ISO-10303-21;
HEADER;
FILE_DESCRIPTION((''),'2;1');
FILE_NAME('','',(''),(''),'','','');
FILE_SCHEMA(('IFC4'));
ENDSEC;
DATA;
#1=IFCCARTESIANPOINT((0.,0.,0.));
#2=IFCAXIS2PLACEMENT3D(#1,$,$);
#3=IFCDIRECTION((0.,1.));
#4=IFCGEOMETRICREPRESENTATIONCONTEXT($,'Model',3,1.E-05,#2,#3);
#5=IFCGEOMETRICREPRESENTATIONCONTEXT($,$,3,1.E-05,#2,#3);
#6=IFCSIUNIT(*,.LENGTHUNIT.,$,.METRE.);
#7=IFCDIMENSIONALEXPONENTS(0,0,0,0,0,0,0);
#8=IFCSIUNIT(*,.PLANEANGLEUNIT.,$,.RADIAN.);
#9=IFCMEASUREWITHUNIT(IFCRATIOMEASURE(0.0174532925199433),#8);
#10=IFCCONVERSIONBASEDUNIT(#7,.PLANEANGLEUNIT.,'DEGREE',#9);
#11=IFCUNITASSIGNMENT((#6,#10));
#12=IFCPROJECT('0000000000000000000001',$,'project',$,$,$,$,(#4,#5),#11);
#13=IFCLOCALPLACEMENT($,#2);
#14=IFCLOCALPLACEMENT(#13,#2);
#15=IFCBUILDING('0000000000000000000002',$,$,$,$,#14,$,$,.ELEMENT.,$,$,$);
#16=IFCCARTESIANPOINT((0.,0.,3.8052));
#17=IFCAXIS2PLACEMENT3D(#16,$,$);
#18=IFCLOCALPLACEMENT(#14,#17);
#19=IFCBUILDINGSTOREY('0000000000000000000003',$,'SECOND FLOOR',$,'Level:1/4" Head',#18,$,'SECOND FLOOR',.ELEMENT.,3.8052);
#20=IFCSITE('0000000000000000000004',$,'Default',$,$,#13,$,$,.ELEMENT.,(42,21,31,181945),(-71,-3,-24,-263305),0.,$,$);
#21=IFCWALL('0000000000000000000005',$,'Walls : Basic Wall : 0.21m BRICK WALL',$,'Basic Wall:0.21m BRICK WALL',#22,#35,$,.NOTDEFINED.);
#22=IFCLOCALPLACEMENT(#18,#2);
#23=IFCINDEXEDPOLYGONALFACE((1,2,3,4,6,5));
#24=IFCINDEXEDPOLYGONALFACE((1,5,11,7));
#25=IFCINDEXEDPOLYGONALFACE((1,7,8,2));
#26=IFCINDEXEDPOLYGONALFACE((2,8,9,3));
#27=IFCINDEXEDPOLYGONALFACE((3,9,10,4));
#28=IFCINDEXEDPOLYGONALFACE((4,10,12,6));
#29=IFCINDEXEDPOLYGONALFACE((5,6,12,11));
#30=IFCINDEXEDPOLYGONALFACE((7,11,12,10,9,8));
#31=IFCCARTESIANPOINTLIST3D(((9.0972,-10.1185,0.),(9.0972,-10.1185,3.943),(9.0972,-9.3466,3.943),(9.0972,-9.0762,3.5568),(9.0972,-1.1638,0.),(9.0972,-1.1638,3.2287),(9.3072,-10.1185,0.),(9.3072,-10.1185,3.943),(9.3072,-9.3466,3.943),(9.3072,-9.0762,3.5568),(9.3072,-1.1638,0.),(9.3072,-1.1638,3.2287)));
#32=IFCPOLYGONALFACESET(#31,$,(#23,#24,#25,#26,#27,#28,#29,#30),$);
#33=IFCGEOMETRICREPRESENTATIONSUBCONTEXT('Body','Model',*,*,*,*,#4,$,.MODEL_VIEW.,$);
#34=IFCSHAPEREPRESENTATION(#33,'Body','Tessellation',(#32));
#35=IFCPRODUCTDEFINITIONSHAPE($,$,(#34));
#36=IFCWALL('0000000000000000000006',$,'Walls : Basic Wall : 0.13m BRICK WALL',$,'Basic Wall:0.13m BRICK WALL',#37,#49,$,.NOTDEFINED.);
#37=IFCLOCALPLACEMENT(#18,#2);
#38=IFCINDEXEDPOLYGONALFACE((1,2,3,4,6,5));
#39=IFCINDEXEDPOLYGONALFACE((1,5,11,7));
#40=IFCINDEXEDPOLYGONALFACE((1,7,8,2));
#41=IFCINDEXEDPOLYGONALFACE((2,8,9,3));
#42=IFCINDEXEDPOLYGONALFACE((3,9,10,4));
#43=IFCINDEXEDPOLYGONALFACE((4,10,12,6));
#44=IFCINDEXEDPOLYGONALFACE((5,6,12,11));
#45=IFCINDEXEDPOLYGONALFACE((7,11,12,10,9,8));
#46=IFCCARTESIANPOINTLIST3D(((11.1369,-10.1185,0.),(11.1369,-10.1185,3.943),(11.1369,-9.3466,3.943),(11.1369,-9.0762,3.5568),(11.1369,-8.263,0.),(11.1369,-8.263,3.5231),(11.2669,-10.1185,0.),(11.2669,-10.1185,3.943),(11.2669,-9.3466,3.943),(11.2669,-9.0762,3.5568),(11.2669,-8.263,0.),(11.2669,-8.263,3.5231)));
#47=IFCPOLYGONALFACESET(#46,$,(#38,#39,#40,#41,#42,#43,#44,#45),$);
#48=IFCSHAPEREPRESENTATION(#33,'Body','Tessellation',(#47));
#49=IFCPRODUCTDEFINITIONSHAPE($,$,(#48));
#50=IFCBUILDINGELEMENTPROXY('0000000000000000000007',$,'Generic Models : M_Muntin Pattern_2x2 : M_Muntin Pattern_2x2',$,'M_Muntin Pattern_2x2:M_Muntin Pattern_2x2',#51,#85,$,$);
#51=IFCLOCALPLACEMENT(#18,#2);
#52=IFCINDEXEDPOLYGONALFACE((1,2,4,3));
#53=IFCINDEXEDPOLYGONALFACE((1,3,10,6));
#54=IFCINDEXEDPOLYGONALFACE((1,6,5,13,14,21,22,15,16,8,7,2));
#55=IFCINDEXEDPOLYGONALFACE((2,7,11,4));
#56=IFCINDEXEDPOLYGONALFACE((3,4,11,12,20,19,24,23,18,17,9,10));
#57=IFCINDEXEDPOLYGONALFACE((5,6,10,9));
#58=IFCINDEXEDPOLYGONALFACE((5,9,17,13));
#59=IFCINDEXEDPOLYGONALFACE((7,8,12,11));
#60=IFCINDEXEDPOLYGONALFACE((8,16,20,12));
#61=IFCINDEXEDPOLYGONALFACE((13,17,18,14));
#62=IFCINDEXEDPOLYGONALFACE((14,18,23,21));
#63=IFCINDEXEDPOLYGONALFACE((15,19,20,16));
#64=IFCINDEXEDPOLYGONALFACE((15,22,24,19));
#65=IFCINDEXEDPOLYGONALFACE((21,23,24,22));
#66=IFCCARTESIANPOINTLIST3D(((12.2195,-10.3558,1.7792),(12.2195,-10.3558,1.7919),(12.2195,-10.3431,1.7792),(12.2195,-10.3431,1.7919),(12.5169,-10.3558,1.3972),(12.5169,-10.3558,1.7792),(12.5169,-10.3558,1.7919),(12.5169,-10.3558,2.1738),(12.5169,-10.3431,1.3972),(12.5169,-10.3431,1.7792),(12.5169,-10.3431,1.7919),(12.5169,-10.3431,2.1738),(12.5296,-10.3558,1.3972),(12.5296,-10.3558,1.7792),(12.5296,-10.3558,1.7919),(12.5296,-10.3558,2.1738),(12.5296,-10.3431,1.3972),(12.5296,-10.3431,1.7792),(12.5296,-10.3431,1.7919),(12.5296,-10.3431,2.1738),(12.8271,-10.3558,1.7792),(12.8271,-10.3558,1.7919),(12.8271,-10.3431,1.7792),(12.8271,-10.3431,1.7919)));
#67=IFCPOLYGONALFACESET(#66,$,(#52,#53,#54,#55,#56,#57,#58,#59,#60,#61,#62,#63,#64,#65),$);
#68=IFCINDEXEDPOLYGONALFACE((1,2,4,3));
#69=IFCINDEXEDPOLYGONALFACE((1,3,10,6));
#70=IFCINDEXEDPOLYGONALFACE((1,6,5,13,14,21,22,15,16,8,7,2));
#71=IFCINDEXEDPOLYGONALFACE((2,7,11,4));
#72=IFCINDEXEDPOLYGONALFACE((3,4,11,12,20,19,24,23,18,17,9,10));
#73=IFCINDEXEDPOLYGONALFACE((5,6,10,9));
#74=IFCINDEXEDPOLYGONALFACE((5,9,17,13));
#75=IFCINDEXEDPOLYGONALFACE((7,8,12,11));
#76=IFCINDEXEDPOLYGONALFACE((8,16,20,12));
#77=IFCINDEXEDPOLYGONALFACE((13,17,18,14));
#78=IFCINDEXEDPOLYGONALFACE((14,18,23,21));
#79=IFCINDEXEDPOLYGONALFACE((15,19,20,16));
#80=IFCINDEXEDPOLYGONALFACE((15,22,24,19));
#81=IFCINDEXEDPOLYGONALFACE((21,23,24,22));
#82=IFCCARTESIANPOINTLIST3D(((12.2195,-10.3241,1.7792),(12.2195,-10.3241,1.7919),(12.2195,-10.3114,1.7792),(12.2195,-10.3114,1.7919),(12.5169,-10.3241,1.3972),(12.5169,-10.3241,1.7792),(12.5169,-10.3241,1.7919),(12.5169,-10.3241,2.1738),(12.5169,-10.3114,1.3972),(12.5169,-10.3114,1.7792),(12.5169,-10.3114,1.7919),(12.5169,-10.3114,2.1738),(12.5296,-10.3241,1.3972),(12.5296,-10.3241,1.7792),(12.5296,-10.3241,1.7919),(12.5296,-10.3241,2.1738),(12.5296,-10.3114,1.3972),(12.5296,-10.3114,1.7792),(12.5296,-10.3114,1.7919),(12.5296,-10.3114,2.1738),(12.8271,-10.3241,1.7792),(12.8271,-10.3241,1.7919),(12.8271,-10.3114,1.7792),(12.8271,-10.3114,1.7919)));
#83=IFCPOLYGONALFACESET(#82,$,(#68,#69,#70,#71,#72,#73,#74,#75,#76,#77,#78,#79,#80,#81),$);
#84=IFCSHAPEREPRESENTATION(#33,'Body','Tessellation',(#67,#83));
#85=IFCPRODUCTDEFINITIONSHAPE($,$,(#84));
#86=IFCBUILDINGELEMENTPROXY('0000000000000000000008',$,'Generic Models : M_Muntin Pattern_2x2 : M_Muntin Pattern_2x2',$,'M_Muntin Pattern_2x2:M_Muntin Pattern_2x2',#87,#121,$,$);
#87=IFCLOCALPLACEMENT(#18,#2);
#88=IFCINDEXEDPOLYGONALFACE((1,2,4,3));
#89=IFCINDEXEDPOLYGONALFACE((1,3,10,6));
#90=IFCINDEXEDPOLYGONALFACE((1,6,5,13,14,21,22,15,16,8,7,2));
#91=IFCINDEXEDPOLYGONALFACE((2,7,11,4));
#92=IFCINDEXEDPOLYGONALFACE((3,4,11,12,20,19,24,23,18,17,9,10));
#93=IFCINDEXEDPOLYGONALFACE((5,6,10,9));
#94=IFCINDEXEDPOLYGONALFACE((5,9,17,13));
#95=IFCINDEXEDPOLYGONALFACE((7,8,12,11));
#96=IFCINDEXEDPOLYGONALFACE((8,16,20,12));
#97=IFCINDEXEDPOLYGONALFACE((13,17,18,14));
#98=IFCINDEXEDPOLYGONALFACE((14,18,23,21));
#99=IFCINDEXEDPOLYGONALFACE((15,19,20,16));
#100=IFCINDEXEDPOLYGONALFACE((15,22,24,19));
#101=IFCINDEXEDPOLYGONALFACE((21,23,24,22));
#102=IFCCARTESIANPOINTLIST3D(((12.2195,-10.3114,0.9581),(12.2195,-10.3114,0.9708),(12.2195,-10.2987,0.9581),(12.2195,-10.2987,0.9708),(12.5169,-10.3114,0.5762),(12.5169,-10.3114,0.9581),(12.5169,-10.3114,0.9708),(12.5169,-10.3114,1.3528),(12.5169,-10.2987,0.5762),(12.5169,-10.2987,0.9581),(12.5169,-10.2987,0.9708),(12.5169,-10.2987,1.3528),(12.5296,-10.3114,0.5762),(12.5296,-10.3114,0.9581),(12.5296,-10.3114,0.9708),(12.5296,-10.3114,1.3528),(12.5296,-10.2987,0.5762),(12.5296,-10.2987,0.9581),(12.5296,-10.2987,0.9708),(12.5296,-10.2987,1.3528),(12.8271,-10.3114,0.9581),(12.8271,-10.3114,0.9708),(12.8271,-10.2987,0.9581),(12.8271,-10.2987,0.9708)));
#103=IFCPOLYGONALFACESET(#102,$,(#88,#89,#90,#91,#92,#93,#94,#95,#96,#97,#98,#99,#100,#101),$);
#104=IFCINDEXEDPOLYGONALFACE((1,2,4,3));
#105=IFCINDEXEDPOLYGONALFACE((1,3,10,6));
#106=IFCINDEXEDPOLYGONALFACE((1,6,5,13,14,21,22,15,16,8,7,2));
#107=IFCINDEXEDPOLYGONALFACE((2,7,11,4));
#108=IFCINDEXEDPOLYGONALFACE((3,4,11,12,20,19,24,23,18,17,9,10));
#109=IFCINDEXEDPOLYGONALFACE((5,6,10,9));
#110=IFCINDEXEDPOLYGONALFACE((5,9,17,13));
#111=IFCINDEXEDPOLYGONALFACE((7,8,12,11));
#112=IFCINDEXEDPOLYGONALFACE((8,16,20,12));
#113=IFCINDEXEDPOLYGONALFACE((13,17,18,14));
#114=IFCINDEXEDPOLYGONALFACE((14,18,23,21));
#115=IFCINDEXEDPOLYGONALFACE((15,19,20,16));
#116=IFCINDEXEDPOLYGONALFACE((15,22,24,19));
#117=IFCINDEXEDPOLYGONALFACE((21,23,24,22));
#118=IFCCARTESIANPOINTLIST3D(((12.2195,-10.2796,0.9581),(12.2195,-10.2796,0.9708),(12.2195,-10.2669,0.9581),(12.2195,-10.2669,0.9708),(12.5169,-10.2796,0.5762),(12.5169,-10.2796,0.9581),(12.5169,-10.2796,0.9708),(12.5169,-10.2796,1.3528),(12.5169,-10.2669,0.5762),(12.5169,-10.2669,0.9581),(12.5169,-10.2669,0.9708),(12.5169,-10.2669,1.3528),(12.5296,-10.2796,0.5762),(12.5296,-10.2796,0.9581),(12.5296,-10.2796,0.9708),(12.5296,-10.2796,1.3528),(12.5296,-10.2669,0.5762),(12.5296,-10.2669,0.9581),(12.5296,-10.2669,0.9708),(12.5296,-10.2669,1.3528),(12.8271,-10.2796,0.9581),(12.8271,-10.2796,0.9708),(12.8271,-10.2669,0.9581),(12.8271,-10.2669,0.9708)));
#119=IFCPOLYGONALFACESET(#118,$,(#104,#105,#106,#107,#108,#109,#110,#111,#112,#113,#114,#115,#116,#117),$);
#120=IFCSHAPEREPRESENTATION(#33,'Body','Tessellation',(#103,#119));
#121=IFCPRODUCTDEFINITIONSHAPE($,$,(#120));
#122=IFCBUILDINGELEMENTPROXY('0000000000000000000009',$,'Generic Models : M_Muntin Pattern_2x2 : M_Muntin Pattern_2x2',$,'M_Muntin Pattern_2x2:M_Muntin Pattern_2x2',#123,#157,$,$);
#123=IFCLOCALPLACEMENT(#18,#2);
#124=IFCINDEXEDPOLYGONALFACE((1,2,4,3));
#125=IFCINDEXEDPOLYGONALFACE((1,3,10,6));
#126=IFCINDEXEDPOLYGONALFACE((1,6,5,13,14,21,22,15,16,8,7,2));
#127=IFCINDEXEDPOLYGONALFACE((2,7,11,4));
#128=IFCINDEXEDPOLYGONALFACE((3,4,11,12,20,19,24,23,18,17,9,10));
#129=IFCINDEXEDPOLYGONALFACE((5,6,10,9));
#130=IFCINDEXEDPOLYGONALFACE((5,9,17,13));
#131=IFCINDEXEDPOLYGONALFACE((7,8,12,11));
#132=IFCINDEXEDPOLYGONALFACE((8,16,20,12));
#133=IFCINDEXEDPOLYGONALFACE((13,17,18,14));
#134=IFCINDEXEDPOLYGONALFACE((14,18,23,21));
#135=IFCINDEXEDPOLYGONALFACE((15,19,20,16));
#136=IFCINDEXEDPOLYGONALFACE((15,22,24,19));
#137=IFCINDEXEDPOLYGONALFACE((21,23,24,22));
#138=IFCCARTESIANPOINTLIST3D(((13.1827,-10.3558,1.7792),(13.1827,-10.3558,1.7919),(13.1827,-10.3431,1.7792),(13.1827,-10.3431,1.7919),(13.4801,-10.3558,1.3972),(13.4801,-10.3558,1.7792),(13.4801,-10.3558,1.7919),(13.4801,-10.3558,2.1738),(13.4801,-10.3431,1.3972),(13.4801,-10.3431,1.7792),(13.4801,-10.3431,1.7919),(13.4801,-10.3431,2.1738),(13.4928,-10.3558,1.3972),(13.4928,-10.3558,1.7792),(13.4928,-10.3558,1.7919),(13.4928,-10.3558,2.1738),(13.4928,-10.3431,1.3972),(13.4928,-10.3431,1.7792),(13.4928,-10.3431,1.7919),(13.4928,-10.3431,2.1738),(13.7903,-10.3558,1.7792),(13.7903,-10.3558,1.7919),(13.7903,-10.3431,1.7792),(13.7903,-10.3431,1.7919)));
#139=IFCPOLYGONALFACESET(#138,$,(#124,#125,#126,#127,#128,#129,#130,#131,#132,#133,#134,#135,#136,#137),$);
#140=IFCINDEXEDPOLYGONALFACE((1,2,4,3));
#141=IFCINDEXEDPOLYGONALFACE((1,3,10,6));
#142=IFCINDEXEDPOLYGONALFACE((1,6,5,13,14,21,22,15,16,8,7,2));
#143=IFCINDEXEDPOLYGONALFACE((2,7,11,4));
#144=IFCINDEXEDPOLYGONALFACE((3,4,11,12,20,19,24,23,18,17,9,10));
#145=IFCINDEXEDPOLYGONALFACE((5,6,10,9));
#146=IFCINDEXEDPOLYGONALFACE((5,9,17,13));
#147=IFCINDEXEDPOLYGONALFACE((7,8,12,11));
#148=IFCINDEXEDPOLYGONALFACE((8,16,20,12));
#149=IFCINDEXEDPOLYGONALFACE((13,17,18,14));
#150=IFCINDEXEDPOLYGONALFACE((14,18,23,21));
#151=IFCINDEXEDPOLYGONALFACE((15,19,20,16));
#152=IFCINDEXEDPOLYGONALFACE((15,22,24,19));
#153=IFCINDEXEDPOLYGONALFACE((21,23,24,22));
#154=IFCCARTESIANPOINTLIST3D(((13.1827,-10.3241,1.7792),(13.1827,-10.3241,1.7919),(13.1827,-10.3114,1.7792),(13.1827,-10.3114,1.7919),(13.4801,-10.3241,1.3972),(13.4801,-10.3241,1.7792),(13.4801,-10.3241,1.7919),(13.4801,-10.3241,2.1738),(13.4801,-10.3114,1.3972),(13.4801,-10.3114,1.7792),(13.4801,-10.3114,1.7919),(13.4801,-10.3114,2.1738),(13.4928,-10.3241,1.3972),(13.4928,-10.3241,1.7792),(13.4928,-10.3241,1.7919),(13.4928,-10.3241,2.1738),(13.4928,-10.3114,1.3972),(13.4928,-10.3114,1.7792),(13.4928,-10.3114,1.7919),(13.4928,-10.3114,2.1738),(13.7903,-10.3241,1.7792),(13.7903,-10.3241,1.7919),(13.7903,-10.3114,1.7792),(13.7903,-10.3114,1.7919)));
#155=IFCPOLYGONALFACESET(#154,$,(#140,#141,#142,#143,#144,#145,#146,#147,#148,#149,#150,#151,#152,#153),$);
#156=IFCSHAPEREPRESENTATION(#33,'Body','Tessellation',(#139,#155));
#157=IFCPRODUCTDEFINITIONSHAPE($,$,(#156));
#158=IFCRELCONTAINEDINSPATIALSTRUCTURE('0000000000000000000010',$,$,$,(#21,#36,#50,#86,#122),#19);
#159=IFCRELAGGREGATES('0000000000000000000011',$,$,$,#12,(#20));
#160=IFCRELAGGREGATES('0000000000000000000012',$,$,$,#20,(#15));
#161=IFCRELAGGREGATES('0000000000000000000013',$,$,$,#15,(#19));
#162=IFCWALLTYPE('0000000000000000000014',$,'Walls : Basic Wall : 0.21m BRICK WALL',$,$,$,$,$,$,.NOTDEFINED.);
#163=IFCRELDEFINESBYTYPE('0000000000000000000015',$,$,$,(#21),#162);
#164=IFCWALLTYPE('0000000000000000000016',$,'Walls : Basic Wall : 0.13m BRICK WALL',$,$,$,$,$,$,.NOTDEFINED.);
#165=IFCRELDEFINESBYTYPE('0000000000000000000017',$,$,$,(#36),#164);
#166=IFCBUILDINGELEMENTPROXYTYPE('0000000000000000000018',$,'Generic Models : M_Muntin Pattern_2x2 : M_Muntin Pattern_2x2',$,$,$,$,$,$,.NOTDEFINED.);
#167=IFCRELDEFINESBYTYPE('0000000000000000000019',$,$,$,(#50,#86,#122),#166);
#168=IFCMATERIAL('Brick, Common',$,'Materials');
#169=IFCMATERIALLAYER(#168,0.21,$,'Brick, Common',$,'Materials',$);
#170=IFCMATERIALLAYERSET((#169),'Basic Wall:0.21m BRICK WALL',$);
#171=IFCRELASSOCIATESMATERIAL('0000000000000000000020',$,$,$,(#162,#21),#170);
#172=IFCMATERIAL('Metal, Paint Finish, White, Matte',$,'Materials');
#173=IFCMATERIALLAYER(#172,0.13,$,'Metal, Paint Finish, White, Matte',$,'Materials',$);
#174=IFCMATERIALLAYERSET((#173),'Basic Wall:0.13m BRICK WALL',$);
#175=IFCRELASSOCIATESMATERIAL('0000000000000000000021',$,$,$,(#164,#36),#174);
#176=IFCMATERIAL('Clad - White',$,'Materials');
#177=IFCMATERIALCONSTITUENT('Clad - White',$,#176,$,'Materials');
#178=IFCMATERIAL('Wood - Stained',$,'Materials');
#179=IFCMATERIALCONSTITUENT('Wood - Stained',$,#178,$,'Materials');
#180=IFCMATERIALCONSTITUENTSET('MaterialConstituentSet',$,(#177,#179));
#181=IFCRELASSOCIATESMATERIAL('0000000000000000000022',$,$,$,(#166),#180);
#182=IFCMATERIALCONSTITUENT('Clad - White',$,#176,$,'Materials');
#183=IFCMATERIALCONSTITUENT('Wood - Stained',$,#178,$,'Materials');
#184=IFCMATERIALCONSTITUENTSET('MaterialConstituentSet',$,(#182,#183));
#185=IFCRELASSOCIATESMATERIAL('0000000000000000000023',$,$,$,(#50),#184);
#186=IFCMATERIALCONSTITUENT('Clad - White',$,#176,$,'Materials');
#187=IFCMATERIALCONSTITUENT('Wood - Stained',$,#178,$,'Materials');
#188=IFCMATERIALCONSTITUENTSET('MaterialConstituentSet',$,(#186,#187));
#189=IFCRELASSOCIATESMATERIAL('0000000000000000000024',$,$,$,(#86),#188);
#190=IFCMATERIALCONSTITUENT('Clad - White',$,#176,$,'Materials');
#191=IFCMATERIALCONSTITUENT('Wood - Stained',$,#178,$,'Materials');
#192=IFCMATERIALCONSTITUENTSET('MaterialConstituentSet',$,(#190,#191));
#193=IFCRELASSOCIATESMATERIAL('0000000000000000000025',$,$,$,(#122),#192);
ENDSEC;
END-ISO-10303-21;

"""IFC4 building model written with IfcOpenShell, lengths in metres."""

from ifc_helpers import new_model, entity, si_unit, converted_unit, direction, frame, frame_2d, origin, place, context, subcontext, project, spatial, polyline, rectangle, outline, extrude, clip, bounded_halfspace, source, transform, mapped, material, layer, layer_set, layer_usage, constituent, constituent_set, type_object, type_shapes, element, save


model = new_model("IFC4")

# Units and contexts
model_context = context("Model", 3, precision=1e-05, world=origin(), true_north=direction((0.0, 1.0)))
context_of_model = context(None, 3, precision=1e-05, world=origin(), true_north=direction((0.0, 1.0)))
body_context = subcontext(model_context, "Body", "Model", "MODEL_VIEW")
ifc_project = project(units=[si_unit("LENGTHUNIT", "METRE"), converted_unit("PLANEANGLEUNIT", "DEGREE", entity("IfcRatioMeasure", 0.0174532925199433), si_unit("PLANEANGLEUNIT", "RADIAN"), dimensions=[0, 0, 0, 0, 0, 0, 0])], contexts=[model_context, context_of_model])

# Site, building, storey
site_placement = place(None, origin())
site = spatial("IfcSite", under=ifc_project, at=site_placement, Name="Default", CompositionType="ELEMENT", RefLatitude=(42, 21, 31, 181945), RefLongitude=(-71, -3, -24, -263305), RefElevation=0.0)
building_placement = place(site_placement, origin())
building = spatial("IfcBuilding", under=site, at=building_placement, CompositionType="ELEMENT")
storey_placement = place(building_placement, frame((0.0, 0.0, 3.8052)))
storey = spatial("IfcBuildingStorey", under=building, at=storey_placement, Name="SECOND FLOOR", ObjectType="Level:1/4\" Head", LongName="SECOND FLOOR", CompositionType="ELEMENT", Elevation=3.8052)

# Walls
ifc_material_1 = material(Name="Brick, Common", Category="Materials")
ifc_layer_1 = layer(ifc_material_1, 0.21, Name="Brick, Common", Category="Materials")
ifc_layer_set_1 = layer_set([ifc_layer_1], Name="Basic Wall:0.21m BRICK WALL")
ifc_layer_usage_1 = layer_usage(ifc_layer_set_1, "AXIS2", "NEGATIVE", 0.105)
wall_type_1 = type_object("IfcWallType", Name="Walls : Basic Wall : 0.21m BRICK WALL", PredefinedType="NOTDEFINED", material=ifc_layer_set_1)
wall_1_placement = place(storey_placement, frame((9.2022, -10.1185, 0.0), z_axis=(0.0, 0.0, 1.0), x_axis=(0.0, 1.0, 0.0)))
element("IfcWall", 1, at=wall_1_placement, inside=storey, type_object=wall_type_1, material=ifc_layer_usage_1, Name="Walls : Basic Wall : 0.21m BRICK WALL", ObjectType="Basic Wall:0.21m BRICK WALL", PredefinedType="NOTDEFINED", context=body_context, shape_type="Clipping", body=[
    clip(clip(clip(extrude(rectangle(XDim=8.9547, YDim=0.21, at=frame_2d((4.4774, 0.0), x_axis=(-1.0, 0.0))), origin(), (0.0, 0.0, 1.0), 3.943), bounded_halfspace(frame((0.0, -0.105, 3.943), z_axis=(0.0, 0.0, -1.0), x_axis=(0.0, 1.0, 0.0)), True, frame((0.0, -0.105, 3.943)), polyline([(0.0, 0.0), (0.7719, 0.0), (0.7719, 0.21), (0.0, 0.21), (0.0, 0.0)]))), bounded_halfspace(frame((0.7719, -0.105, 3.943), z_axis=(-0.819152, 0.0, -0.573576), x_axis=(0.0, 1.0, 0.0)), True, frame((0.7719, -0.105, 3.943)), polyline([(0.0, 0.0), (0.2704, 0.0), (0.2704, 0.21), (0.0, 0.21), (0.0, 0.0)]))), bounded_halfspace(frame((1.0423, -0.105, 3.5568), z_axis=(-0.041435, 0.0, -0.999141), x_axis=(0.0, 1.0, 0.0)), True, frame((1.0423, -0.105, 3.5568)), polyline([(0.0, 0.0), (7.6624, 0.0), (7.9124, 0.0), (7.9124, 0.21), (0.0, 0.21), (0.0, 0.0)]))),
])
ifc_material_2 = material(Name="Metal, Paint Finish, White, Matte", Category="Materials")
ifc_layer_2 = layer(ifc_material_2, 0.13, Name="Metal, Paint Finish, White, Matte", Category="Materials")
ifc_layer_set_2 = layer_set([ifc_layer_2], Name="Basic Wall:0.13m BRICK WALL")
ifc_layer_usage_2 = layer_usage(ifc_layer_set_2, "AXIS2", "NEGATIVE", 0.065)
wall_type_2 = type_object("IfcWallType", Name="Walls : Basic Wall : 0.13m BRICK WALL", PredefinedType="NOTDEFINED", material=ifc_layer_set_2)
wall_2_placement = place(storey_placement, frame((11.2019, -10.1185, 0.0), z_axis=(0.0, 0.0, 1.0), x_axis=(0.0, 1.0, 0.0)))
element("IfcWall", 2, at=wall_2_placement, inside=storey, type_object=wall_type_2, material=ifc_layer_usage_2, Name="Walls : Basic Wall : 0.13m BRICK WALL", ObjectType="Basic Wall:0.13m BRICK WALL", PredefinedType="NOTDEFINED", context=body_context, shape_type="Clipping", body=[
    clip(clip(clip(extrude(rectangle(XDim=1.8555, YDim=0.13, at=frame_2d((0.9277, 0.0), x_axis=(-1.0, 0.0))), origin(), (0.0, 0.0, 1.0), 3.943), bounded_halfspace(frame((0.0, -0.065, 3.943), z_axis=(0.0, 0.0, -1.0), x_axis=(0.0, 1.0, 0.0)), True, frame((0.0, -0.065, 3.943)), polyline([(0.0, 0.0), (0.7719, 0.0), (0.7719, 0.13), (0.0, 0.13), (0.0, 0.0)]))), bounded_halfspace(frame((0.7719, -0.065, 3.943), z_axis=(-0.819152, 0.0, -0.573576), x_axis=(0.0, 1.0, 0.0)), True, frame((0.7719, -0.065, 3.943)), polyline([(0.0, 0.0), (0.2704, 0.0), (0.2704, 0.13), (0.0, 0.13), (0.0, 0.0)]))), bounded_halfspace(frame((1.0423, -0.065, 3.5568), z_axis=(-0.041435, 0.0, -0.999141), x_axis=(0.0, 1.0, 0.0)), True, frame((1.0423, -0.065, 3.5568)), polyline([(0.0, 0.0), (0.7032, 0.0), (0.8132, 0.0), (0.8132, 0.13), (0.0, 0.13), (0.0, 0.0)]))),
])

# Shared definitions
ifc_material_3 = material(Name="Wood - Stained", Category="Materials")

# Building element proxies
ifc_material_4 = material(Name="Clad - White", Category="Materials")
ifc_constituent_1 = constituent(ifc_material_4, Name="Clad - White", Category="Materials")
ifc_constituent_2 = constituent(ifc_material_3, Name="Wood - Stained", Category="Materials")
ifc_constituent_set_1 = constituent_set(constituents=[ifc_constituent_1, ifc_constituent_2], Name="MaterialConstituentSet")
ifc_constituent_3 = constituent(ifc_material_4, Name="Clad - White", Category="Materials")
ifc_constituent_4 = constituent(ifc_material_3, Name="Wood - Stained", Category="Materials")
ifc_constituent_set_2 = constituent_set(constituents=[ifc_constituent_3, ifc_constituent_4], Name="MaterialConstituentSet")
building_element_proxy_type_1 = type_object("IfcBuildingElementProxyType", Name="Generic Models : M_Muntin Pattern_2x2 : M_Muntin Pattern_2x2", PredefinedType="NOTDEFINED", material=ifc_constituent_set_2)
shared_shape_1 = source(origin(), body_context, "Body", "SweptSolid", [
    extrude(outline(polyline([(0.0064, -0.0064), (0.3883, -0.0064), (0.3883, 0.0063), (0.0064, 0.0063), (0.0064, 0.3038), (-0.0063, 0.3038), (-0.0063, 0.0063), (-0.3883, 0.0063), (-0.3883, -0.0064), (-0.0063, -0.0064), (-0.0063, -0.3038), (0.0064, -0.3038), (0.0064, -0.0064)])), frame((0.0, 0.0095, 0.3883), z_axis=(0.0, 1.0, 0.0), x_axis=(0.0, 0.0, 1.0)), (0.0, 0.0, 1.0), 0.0127),
    extrude(outline(polyline([(0.0064, -0.0064), (0.3883, -0.0064), (0.3883, 0.0063), (0.0064, 0.0063), (0.0064, 0.3038), (-0.0063, 0.3038), (-0.0063, 0.0063), (-0.3883, 0.0063), (-0.3883, -0.0064), (-0.0063, -0.0064), (-0.0063, -0.3038), (0.0064, -0.3038), (0.0064, -0.0064)])), frame((0.0, -0.0222, 0.3883), z_axis=(0.0, 1.0, 0.0), x_axis=(0.0, 0.0, 1.0)), (0.0, 0.0, 1.0), 0.0127),
])
type_shapes(building_element_proxy_type_1, [shared_shape_1])
proxy_1_placement = place(storey_placement, frame((12.5233, -10.3336, 1.3972), z_axis=(0.0, 0.0, 1.0), x_axis=(-1.0, 0.0, 0.0)))
element("IfcBuildingElementProxy", 3, at=proxy_1_placement, inside=storey, type_object=building_element_proxy_type_1, material=ifc_constituent_set_1, Name="Generic Models : M_Muntin Pattern_2x2 : M_Muntin Pattern_2x2", ObjectType="M_Muntin Pattern_2x2:M_Muntin Pattern_2x2", context=body_context, shape_type="MappedRepresentation", body=[
    mapped(shared_shape_1, transform((0.0, 0.0, 0.0), scale=1.0)),
])
ifc_constituent_5 = constituent(ifc_material_4, Name="Clad - White", Category="Materials")
ifc_constituent_6 = constituent(ifc_material_3, Name="Wood - Stained", Category="Materials")
ifc_constituent_set_3 = constituent_set(constituents=[ifc_constituent_5, ifc_constituent_6], Name="MaterialConstituentSet")
proxy_2_placement = place(storey_placement, frame((12.5233, -10.2891, 0.5762), z_axis=(0.0, 0.0, 1.0), x_axis=(-1.0, 0.0, 0.0)))
element("IfcBuildingElementProxy", 4, at=proxy_2_placement, inside=storey, type_object=building_element_proxy_type_1, material=ifc_constituent_set_3, Name="Generic Models : M_Muntin Pattern_2x2 : M_Muntin Pattern_2x2", ObjectType="M_Muntin Pattern_2x2:M_Muntin Pattern_2x2", context=body_context, shape_type="MappedRepresentation", body=[
    mapped(shared_shape_1, transform((0.0, 0.0, 0.0), scale=1.0)),
])
ifc_constituent_7 = constituent(ifc_material_4, Name="Clad - White", Category="Materials")
ifc_constituent_8 = constituent(ifc_material_3, Name="Wood - Stained", Category="Materials")
ifc_constituent_set_4 = constituent_set(constituents=[ifc_constituent_7, ifc_constituent_8], Name="MaterialConstituentSet")
proxy_3_placement = place(storey_placement, frame((13.4865, -10.3336, 1.3972), z_axis=(0.0, 0.0, 1.0), x_axis=(-1.0, 0.0, 0.0)))
element("IfcBuildingElementProxy", 5, at=proxy_3_placement, inside=storey, type_object=building_element_proxy_type_1, material=ifc_constituent_set_4, Name="Generic Models : M_Muntin Pattern_2x2 : M_Muntin Pattern_2x2", ObjectType="M_Muntin Pattern_2x2:M_Muntin Pattern_2x2", context=body_context, shape_type="MappedRepresentation", body=[
    mapped(shared_shape_1, transform((0.0, 0.0, 0.0), scale=1.0)),
])

save(model, "model.ifc")
